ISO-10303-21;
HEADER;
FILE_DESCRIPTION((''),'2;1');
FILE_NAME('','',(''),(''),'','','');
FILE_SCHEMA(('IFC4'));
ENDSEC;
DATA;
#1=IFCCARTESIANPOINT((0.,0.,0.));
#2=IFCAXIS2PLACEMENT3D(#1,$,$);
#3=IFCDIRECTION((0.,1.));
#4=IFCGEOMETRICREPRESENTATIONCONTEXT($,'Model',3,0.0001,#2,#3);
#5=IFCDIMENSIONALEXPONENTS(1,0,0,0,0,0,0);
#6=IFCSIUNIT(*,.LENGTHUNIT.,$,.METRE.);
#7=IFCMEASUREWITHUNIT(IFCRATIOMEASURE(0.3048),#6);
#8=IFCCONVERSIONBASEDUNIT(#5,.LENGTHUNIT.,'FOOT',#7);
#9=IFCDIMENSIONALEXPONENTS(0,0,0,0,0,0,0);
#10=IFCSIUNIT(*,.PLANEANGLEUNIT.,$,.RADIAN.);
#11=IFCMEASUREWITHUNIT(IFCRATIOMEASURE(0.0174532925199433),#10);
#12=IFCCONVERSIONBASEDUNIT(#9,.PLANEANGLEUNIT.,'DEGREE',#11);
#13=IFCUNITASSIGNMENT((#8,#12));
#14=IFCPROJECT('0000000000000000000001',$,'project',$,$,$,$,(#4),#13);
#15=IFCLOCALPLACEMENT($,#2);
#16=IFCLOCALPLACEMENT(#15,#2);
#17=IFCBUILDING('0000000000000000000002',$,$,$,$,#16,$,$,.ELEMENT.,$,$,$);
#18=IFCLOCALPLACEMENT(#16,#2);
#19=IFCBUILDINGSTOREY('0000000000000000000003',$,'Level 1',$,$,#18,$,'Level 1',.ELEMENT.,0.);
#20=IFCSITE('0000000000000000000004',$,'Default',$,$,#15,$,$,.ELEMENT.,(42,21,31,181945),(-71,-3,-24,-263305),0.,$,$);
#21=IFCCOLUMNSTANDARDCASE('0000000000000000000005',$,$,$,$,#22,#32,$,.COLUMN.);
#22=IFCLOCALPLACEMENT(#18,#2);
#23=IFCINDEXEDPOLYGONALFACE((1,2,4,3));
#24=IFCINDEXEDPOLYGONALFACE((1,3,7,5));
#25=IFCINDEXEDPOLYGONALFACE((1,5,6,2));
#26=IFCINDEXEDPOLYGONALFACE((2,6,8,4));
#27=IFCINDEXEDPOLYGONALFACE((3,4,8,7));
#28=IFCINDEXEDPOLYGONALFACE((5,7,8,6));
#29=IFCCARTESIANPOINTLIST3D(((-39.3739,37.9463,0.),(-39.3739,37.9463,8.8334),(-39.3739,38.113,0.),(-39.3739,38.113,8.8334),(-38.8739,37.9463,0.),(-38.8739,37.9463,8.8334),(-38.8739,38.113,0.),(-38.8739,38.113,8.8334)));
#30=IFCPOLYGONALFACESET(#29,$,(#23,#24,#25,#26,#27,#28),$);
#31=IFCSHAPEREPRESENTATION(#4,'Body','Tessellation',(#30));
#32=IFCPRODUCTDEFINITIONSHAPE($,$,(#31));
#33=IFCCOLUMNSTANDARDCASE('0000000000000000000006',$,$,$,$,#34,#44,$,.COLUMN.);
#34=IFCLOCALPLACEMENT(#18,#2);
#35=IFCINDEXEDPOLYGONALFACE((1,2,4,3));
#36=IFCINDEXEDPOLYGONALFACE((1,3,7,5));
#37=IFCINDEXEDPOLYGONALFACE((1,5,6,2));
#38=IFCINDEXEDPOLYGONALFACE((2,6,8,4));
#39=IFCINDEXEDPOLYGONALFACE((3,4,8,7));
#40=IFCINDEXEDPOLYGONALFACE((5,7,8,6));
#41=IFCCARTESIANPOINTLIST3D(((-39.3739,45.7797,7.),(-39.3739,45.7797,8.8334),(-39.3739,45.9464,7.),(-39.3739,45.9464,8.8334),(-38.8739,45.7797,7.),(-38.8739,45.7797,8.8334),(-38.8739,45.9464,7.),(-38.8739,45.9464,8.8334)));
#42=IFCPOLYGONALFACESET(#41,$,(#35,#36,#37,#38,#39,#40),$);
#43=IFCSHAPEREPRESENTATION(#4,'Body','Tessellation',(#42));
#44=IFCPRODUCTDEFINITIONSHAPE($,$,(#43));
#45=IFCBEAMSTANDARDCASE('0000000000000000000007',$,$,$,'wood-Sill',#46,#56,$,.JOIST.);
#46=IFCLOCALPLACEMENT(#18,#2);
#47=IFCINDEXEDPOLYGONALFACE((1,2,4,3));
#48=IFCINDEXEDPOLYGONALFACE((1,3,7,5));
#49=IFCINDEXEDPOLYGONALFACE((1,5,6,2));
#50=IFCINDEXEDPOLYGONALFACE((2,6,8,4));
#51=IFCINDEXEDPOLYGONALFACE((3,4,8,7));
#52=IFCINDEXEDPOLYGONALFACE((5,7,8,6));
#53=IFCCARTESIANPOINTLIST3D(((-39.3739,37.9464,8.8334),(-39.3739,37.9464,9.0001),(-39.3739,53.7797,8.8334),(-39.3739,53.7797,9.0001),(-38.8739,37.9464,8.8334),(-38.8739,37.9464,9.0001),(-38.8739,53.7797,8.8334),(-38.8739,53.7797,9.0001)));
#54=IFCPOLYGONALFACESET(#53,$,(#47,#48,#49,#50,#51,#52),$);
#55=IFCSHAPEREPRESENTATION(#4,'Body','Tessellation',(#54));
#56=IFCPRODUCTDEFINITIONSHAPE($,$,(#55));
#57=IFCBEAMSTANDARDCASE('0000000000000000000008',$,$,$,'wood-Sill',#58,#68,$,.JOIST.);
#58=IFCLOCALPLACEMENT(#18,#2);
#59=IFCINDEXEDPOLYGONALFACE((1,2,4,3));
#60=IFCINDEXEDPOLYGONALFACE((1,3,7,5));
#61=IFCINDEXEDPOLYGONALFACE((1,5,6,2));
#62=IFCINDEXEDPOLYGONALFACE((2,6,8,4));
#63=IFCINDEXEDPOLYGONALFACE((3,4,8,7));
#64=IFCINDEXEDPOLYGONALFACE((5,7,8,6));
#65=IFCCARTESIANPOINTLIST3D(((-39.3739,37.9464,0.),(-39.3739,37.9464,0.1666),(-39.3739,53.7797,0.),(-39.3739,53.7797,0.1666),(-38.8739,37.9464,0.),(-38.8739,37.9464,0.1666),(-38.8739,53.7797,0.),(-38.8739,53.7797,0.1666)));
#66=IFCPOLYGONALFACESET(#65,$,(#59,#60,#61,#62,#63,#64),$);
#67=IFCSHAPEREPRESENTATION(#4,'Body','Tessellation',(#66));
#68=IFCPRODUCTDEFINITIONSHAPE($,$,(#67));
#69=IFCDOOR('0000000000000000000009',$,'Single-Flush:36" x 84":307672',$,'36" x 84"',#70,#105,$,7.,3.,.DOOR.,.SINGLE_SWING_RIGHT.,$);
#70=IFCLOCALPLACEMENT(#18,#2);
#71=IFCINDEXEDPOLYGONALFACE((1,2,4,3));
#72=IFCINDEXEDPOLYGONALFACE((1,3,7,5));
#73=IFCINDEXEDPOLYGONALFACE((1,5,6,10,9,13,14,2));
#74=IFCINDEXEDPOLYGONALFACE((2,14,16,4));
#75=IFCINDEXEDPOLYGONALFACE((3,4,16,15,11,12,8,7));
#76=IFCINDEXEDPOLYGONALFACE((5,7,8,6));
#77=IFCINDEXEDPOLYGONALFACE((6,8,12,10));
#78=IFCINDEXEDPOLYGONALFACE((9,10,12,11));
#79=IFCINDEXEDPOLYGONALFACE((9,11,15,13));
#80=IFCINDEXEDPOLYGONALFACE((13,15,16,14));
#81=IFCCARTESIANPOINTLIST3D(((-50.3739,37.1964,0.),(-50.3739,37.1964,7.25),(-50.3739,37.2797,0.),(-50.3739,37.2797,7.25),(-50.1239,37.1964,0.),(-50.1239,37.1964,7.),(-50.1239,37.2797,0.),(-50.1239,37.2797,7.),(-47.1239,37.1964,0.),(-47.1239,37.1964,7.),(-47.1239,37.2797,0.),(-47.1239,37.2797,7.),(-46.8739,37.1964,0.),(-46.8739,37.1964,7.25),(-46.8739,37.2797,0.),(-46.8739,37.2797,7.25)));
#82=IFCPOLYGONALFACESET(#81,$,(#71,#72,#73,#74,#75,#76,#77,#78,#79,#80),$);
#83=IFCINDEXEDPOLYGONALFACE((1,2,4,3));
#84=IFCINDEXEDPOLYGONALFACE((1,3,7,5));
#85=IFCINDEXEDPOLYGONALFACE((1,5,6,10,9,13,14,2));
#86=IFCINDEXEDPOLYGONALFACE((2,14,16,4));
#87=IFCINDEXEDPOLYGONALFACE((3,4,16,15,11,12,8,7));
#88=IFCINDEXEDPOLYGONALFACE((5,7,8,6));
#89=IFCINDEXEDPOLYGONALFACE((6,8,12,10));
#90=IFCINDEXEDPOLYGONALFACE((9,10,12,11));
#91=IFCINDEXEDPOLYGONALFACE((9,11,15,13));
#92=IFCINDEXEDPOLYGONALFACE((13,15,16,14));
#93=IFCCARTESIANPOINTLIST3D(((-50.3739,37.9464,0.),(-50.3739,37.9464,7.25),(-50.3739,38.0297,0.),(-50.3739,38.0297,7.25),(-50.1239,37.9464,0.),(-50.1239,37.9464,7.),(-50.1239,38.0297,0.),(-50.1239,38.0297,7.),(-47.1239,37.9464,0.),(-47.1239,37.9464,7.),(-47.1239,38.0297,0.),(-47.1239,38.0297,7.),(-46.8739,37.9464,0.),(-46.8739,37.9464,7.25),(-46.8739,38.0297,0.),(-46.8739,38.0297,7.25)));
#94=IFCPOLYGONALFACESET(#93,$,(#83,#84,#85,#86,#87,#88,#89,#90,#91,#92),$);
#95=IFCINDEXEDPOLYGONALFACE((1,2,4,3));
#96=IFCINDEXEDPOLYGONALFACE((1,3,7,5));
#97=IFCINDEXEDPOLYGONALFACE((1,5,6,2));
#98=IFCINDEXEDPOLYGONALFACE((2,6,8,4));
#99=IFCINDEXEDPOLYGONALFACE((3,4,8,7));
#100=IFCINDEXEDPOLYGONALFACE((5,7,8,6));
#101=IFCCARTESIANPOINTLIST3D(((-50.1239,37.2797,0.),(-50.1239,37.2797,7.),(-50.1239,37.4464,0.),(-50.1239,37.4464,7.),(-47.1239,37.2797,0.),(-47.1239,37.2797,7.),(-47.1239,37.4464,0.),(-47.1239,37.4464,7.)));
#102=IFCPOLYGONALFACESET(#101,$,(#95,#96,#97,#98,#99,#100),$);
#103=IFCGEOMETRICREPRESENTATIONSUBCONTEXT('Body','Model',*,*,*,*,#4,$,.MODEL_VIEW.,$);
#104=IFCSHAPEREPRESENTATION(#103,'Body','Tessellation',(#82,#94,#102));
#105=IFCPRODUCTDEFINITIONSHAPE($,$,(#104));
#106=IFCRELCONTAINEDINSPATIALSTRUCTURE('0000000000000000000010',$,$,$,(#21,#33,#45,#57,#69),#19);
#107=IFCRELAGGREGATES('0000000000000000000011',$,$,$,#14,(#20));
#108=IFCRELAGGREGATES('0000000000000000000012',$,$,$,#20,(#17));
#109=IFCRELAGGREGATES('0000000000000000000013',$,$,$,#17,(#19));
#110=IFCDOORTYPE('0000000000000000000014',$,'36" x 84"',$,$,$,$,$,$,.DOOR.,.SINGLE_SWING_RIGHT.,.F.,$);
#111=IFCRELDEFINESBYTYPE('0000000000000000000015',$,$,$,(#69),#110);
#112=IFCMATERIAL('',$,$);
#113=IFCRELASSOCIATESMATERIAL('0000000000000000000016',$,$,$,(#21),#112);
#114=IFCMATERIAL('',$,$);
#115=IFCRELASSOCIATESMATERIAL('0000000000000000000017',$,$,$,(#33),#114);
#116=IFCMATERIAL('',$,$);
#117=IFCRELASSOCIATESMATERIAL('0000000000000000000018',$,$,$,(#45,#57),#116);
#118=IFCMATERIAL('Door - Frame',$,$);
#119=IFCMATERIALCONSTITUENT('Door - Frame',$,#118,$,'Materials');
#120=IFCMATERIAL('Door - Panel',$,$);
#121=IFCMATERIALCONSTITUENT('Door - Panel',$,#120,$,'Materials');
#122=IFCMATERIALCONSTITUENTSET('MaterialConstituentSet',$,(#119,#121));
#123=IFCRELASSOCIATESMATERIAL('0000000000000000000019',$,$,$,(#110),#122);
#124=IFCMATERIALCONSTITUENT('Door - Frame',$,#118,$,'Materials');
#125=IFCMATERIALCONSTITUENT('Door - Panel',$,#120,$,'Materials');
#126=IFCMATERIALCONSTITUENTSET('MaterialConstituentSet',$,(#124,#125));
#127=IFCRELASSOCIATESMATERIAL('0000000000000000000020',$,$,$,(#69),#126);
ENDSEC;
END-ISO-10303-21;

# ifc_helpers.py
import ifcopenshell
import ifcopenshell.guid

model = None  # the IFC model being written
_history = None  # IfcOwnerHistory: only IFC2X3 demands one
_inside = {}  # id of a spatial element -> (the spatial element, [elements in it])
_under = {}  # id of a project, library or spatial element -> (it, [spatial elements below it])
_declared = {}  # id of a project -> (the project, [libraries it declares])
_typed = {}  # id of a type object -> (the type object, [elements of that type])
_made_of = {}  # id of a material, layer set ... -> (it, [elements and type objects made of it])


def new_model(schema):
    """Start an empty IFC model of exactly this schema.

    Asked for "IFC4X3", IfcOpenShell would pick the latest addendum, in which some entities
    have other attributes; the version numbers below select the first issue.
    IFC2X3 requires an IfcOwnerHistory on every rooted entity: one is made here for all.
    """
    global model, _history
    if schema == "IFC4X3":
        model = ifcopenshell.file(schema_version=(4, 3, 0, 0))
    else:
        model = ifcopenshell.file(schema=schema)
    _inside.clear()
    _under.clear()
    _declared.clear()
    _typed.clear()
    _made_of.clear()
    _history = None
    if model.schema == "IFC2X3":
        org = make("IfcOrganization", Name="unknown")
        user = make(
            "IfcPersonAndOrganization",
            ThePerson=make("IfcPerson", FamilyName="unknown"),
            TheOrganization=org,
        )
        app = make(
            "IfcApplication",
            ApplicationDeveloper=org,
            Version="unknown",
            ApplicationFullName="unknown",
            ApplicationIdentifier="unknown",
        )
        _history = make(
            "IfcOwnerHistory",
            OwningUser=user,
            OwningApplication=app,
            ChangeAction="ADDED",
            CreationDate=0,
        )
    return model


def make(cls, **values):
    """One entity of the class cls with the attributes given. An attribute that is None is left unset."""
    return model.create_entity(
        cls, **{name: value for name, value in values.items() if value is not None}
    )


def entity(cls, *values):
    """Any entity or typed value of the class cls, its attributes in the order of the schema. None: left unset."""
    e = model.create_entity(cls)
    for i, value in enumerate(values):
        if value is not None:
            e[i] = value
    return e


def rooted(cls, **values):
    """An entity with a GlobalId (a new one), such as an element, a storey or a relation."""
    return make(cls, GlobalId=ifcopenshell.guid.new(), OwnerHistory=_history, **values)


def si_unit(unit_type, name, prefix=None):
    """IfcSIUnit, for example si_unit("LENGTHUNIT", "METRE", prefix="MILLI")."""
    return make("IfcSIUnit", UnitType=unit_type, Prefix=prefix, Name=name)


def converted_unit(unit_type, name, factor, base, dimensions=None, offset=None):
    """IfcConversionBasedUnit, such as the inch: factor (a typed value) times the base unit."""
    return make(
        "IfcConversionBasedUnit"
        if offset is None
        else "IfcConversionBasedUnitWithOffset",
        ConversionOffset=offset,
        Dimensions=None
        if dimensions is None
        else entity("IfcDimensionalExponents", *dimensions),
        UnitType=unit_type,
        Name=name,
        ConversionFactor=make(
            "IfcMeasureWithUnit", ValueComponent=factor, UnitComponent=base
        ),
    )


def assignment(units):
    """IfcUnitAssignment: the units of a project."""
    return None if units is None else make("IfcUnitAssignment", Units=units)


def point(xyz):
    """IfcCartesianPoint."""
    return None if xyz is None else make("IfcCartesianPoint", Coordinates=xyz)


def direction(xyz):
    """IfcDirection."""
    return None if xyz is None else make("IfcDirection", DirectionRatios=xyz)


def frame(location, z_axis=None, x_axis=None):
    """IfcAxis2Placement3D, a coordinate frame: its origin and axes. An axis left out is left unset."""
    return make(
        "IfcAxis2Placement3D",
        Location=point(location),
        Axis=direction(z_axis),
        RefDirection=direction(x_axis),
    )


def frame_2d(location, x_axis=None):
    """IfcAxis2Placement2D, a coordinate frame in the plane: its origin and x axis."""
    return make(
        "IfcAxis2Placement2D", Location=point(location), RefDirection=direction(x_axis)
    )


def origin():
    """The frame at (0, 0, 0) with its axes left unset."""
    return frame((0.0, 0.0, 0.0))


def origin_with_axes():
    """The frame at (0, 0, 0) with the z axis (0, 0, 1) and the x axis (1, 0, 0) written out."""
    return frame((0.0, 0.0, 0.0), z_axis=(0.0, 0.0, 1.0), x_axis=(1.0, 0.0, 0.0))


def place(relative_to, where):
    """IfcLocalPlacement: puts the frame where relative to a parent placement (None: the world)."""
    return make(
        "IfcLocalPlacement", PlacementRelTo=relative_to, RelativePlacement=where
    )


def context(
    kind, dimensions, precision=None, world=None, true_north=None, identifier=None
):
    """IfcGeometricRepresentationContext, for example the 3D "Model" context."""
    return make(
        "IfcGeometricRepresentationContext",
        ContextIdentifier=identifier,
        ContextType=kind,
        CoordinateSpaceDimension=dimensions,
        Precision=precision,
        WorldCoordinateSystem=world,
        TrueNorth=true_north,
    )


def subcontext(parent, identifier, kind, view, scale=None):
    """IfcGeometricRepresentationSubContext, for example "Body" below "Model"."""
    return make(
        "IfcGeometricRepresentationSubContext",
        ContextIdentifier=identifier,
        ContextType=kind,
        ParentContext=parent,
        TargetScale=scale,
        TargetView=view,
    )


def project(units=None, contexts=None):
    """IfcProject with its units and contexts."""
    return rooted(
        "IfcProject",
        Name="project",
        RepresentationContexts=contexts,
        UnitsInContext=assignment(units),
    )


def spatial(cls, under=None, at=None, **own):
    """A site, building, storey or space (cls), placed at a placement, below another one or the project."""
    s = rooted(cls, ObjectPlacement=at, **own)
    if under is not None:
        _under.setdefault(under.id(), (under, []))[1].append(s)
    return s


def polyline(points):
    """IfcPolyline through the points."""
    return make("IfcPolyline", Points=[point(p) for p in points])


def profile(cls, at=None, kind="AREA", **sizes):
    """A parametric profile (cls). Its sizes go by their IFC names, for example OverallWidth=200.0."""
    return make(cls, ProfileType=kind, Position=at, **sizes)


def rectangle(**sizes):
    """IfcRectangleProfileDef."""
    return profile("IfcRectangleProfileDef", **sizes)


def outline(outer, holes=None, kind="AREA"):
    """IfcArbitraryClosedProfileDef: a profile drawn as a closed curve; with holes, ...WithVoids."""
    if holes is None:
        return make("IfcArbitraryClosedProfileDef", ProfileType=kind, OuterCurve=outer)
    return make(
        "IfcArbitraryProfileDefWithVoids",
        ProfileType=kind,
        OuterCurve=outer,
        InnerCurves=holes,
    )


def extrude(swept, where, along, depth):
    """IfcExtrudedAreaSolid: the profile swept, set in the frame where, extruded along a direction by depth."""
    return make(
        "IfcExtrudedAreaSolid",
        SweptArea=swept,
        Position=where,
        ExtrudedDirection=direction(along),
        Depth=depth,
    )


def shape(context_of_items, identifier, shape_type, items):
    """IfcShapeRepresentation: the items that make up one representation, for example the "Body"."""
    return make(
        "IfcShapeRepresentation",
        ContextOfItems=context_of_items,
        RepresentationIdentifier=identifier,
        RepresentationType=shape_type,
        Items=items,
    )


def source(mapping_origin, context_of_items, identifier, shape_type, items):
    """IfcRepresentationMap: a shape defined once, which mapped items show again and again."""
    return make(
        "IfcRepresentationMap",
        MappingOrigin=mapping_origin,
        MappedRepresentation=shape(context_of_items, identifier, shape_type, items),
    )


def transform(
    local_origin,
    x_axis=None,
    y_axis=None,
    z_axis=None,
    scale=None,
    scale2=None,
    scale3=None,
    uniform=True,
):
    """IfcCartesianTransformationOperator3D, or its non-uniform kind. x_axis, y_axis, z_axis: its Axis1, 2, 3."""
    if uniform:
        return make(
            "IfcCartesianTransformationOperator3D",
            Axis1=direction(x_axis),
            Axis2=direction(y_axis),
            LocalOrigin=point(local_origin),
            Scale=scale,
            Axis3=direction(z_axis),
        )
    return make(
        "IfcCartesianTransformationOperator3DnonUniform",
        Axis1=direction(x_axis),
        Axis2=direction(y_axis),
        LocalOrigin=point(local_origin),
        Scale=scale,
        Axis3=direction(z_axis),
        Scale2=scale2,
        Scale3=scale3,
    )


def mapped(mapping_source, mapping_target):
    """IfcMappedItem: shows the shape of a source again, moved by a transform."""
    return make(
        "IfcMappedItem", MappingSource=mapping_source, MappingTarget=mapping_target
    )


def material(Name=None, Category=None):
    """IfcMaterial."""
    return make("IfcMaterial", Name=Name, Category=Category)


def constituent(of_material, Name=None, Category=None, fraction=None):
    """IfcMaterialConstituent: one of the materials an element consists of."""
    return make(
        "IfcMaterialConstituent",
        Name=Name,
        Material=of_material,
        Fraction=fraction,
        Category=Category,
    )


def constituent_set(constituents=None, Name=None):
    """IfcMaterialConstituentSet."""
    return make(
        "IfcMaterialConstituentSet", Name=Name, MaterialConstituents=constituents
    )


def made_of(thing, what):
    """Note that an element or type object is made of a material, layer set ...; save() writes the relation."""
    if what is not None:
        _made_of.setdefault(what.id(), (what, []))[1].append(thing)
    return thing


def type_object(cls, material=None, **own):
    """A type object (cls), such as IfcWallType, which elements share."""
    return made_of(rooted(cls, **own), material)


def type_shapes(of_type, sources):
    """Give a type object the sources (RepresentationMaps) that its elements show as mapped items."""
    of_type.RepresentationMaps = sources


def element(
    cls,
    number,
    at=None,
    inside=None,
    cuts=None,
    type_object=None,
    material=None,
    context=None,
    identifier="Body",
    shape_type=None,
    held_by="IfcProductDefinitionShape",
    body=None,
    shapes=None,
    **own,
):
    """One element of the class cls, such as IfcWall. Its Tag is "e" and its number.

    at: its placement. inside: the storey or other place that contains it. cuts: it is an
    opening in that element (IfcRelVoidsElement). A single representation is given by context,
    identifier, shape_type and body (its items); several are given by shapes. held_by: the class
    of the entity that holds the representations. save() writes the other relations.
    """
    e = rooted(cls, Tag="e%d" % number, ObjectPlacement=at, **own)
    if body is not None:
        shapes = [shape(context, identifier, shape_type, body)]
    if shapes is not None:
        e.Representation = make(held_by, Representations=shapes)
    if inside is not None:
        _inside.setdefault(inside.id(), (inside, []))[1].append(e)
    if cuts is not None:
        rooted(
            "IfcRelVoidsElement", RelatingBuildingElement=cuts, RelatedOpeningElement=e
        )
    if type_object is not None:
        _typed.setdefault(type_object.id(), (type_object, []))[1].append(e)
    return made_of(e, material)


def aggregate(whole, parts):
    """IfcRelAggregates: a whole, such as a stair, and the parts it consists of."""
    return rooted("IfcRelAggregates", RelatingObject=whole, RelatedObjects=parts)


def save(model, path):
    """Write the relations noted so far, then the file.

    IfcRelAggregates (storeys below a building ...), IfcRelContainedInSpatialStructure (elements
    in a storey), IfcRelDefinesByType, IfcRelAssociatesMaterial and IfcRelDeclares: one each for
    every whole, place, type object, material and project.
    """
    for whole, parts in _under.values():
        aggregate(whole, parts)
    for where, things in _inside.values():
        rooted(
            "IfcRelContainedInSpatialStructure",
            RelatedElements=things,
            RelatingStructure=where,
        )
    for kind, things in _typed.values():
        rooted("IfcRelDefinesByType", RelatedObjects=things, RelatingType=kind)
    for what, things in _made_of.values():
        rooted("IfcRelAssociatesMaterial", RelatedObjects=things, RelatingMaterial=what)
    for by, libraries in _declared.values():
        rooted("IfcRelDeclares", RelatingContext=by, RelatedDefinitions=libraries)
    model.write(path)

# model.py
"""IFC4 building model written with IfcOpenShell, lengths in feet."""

from ifc_helpers import new_model, entity, si_unit, converted_unit, direction, frame, frame_2d, origin, origin_with_axes, place, context, subcontext, project, spatial, polyline, rectangle, outline, extrude, source, transform, mapped, material, constituent, constituent_set, type_object, type_shapes, element, save


model = new_model("IFC4")

# Units and contexts
model_context = context("Model", 3, precision=0.0001, world=origin(), true_north=direction((0.0, 1.0)))
body_context = subcontext(model_context, "Body", "Model", "MODEL_VIEW")
ifc_project = project(units=[converted_unit("LENGTHUNIT", "FOOT", entity("IfcRatioMeasure", 0.3048), si_unit("LENGTHUNIT", "METRE"), dimensions=[1, 0, 0, 0, 0, 0, 0]), converted_unit("PLANEANGLEUNIT", "DEGREE", entity("IfcRatioMeasure", 0.0174532925199433), si_unit("PLANEANGLEUNIT", "RADIAN"), dimensions=[0, 0, 0, 0, 0, 0, 0])], contexts=[model_context])

# Site, building, storey
site_placement = place(None, origin())
site = spatial("IfcSite", under=ifc_project, at=site_placement, Name="Default", CompositionType="ELEMENT", RefLatitude=(42, 21, 31, 181945), RefLongitude=(-71, -3, -24, -263305), RefElevation=0.0)
building_placement = place(site_placement, origin())
building = spatial("IfcBuilding", under=site, at=building_placement, CompositionType="ELEMENT")
storey_placement = place(building_placement, origin())
storey = spatial("IfcBuildingStorey", under=building, at=storey_placement, Name="Level 1", LongName="Level 1", CompositionType="ELEMENT", Elevation=0.0)

# Columns
ifc_material_1 = material(Name="")
placement_1 = place(storey_placement, frame((-39.1239, 37.9464, 0.0), z_axis=(0.0, 0.0, 1.0), x_axis=(0.0, 1.0, 0.0)))
for number, where, z_axis, x_axis in (
    (1, (0.0833, 0.0, 0.0), (0.0, 0.0, 1.0), (1.0, 0.0, 0.0)),
):
    element("IfcColumnStandardCase", number, at=place(placement_1, frame(where, z_axis=z_axis, x_axis=x_axis)), inside=storey, material=ifc_material_1, PredefinedType="COLUMN", context=model_context, shape_type="SweptSolid", body=[
        extrude(rectangle(XDim=0.1667, YDim=0.5), origin(), (0.0, 0.0, 1.0), 8.8334),
    ])
ifc_material_2 = material(Name="")
for number, where, z_axis, x_axis in (
    (2, (7.9167, 0.0, 7.0), (0.0, 0.0, 1.0), (1.0, 0.0, 0.0)),
):
    element("IfcColumnStandardCase", number, at=place(placement_1, frame(where, z_axis=z_axis, x_axis=x_axis)), inside=storey, material=ifc_material_2, PredefinedType="COLUMN", context=model_context, shape_type="SweptSolid", body=[
        extrude(rectangle(XDim=0.1667, YDim=0.5), origin(), (0.0, 0.0, 1.0), 1.8334),
    ])

# Beams
placement_2 = place(storey_placement, frame((-21.2906, 37.6131, 0.0), z_axis=(0.0, 0.0, 1.0), x_axis=(-1.0, 0.0, 0.0)))
ifc_material_3 = material(Name="")
for number, where, z_axis, x_axis in (
    (3, (0.0, 0.0, 8.9167), (1.0, 0.0, 0.0), (0.0, 0.0, 1.0)),
    (4, (0.0, 0.0, 0.0833), (1.0, 0.0, 0.0), (0.0, 0.0, 1.0)),
):
    element("IfcBeamStandardCase", number, at=place(placement_1, frame(where, z_axis=z_axis, x_axis=x_axis)), inside=storey, material=ifc_material_3, ObjectType="wood-Sill", PredefinedType="JOIST", context=model_context, shape_type="SweptSolid", body=[
        extrude(rectangle(XDim=0.1667, YDim=0.5), origin_with_axes(), (0.0, 0.0, 1.0), 15.8333),
    ])

# Door
ifc_material_4 = material(Name="Door - Frame")
ifc_constituent_1 = constituent(ifc_material_4, Name="Door - Frame", Category="Materials")
ifc_material_5 = material(Name="Door - Panel")
ifc_constituent_2 = constituent(ifc_material_5, Name="Door - Panel", Category="Materials")
ifc_constituent_set_1 = constituent_set(constituents=[ifc_constituent_1, ifc_constituent_2], Name="MaterialConstituentSet")
ifc_constituent_3 = constituent(ifc_material_4, Name="Door - Frame", Category="Materials")
ifc_constituent_4 = constituent(ifc_material_5, Name="Door - Panel", Category="Materials")
ifc_constituent_set_2 = constituent_set(constituents=[ifc_constituent_3, ifc_constituent_4], Name="MaterialConstituentSet")
door_type = type_object("IfcDoorType", Name="36\" x 84\"", OperationType="SINGLE_SWING_RIGHT", ParameterTakesPrecedence=False, PredefinedType="DOOR", material=ifc_constituent_set_2)
shared_shape = source(origin(), body_context, "Body", "SweptSolid", [
    extrude(outline(polyline([(-1.75, -3.6875), (1.75, -3.6875), (1.75, 3.5625), (1.5, 3.5625), (1.5, -3.4375), (-1.5, -3.4375), (-1.5, 3.5625), (-1.75, 3.5625), (-1.75, -3.6875)])), frame((1.5, 0.6667, 3.5625), z_axis=(0.0, 1.0, 0.0), x_axis=(1.0, 0.0, 0.0)), (0.0, 0.0, 1.0), 0.0833),
    extrude(outline(polyline([(-3.6875, -1.75), (3.5625, -1.75), (3.5625, -1.5), (-3.4375, -1.5), (-3.4375, 1.5), (3.5625, 1.5), (3.5625, 1.75), (-3.6875, 1.75), (-3.6875, -1.75)])), frame((1.5, -0.0833, 3.5625), z_axis=(0.0, 1.0, 0.0), x_axis=(0.0, 0.0, -1.0)), (0.0, 0.0, 1.0), 0.0833),
    extrude(rectangle(XDim=0.1667, YDim=3.0, at=frame_2d((0.0, 0.0), x_axis=(1.0, 0.0))), frame((1.5, 0.5833, 0.0), z_axis=(0.0, 0.0, 1.0), x_axis=(0.0, 1.0, 0.0)), (0.0, 0.0, 1.0), 7.0),
])
type_shapes(door_type, [shared_shape])
placement_3 = place(placement_2, frame((25.8333, -0.3333, 0.0)))
door_placement = place(placement_3, origin())
element("IfcDoor", 5, at=door_placement, inside=storey, type_object=door_type, material=ifc_constituent_set_1, Name="Single-Flush:36\" x 84\":307672", ObjectType="36\" x 84\"", OperationType="SINGLE_SWING_RIGHT", OverallHeight=7.0, OverallWidth=3.0, PredefinedType="DOOR", context=body_context, shape_type="MappedRepresentation", body=[
    mapped(shared_shape, transform((0.0, 0.0, 0.0), scale=1.0)),
])

save(model, "model.ifc")
